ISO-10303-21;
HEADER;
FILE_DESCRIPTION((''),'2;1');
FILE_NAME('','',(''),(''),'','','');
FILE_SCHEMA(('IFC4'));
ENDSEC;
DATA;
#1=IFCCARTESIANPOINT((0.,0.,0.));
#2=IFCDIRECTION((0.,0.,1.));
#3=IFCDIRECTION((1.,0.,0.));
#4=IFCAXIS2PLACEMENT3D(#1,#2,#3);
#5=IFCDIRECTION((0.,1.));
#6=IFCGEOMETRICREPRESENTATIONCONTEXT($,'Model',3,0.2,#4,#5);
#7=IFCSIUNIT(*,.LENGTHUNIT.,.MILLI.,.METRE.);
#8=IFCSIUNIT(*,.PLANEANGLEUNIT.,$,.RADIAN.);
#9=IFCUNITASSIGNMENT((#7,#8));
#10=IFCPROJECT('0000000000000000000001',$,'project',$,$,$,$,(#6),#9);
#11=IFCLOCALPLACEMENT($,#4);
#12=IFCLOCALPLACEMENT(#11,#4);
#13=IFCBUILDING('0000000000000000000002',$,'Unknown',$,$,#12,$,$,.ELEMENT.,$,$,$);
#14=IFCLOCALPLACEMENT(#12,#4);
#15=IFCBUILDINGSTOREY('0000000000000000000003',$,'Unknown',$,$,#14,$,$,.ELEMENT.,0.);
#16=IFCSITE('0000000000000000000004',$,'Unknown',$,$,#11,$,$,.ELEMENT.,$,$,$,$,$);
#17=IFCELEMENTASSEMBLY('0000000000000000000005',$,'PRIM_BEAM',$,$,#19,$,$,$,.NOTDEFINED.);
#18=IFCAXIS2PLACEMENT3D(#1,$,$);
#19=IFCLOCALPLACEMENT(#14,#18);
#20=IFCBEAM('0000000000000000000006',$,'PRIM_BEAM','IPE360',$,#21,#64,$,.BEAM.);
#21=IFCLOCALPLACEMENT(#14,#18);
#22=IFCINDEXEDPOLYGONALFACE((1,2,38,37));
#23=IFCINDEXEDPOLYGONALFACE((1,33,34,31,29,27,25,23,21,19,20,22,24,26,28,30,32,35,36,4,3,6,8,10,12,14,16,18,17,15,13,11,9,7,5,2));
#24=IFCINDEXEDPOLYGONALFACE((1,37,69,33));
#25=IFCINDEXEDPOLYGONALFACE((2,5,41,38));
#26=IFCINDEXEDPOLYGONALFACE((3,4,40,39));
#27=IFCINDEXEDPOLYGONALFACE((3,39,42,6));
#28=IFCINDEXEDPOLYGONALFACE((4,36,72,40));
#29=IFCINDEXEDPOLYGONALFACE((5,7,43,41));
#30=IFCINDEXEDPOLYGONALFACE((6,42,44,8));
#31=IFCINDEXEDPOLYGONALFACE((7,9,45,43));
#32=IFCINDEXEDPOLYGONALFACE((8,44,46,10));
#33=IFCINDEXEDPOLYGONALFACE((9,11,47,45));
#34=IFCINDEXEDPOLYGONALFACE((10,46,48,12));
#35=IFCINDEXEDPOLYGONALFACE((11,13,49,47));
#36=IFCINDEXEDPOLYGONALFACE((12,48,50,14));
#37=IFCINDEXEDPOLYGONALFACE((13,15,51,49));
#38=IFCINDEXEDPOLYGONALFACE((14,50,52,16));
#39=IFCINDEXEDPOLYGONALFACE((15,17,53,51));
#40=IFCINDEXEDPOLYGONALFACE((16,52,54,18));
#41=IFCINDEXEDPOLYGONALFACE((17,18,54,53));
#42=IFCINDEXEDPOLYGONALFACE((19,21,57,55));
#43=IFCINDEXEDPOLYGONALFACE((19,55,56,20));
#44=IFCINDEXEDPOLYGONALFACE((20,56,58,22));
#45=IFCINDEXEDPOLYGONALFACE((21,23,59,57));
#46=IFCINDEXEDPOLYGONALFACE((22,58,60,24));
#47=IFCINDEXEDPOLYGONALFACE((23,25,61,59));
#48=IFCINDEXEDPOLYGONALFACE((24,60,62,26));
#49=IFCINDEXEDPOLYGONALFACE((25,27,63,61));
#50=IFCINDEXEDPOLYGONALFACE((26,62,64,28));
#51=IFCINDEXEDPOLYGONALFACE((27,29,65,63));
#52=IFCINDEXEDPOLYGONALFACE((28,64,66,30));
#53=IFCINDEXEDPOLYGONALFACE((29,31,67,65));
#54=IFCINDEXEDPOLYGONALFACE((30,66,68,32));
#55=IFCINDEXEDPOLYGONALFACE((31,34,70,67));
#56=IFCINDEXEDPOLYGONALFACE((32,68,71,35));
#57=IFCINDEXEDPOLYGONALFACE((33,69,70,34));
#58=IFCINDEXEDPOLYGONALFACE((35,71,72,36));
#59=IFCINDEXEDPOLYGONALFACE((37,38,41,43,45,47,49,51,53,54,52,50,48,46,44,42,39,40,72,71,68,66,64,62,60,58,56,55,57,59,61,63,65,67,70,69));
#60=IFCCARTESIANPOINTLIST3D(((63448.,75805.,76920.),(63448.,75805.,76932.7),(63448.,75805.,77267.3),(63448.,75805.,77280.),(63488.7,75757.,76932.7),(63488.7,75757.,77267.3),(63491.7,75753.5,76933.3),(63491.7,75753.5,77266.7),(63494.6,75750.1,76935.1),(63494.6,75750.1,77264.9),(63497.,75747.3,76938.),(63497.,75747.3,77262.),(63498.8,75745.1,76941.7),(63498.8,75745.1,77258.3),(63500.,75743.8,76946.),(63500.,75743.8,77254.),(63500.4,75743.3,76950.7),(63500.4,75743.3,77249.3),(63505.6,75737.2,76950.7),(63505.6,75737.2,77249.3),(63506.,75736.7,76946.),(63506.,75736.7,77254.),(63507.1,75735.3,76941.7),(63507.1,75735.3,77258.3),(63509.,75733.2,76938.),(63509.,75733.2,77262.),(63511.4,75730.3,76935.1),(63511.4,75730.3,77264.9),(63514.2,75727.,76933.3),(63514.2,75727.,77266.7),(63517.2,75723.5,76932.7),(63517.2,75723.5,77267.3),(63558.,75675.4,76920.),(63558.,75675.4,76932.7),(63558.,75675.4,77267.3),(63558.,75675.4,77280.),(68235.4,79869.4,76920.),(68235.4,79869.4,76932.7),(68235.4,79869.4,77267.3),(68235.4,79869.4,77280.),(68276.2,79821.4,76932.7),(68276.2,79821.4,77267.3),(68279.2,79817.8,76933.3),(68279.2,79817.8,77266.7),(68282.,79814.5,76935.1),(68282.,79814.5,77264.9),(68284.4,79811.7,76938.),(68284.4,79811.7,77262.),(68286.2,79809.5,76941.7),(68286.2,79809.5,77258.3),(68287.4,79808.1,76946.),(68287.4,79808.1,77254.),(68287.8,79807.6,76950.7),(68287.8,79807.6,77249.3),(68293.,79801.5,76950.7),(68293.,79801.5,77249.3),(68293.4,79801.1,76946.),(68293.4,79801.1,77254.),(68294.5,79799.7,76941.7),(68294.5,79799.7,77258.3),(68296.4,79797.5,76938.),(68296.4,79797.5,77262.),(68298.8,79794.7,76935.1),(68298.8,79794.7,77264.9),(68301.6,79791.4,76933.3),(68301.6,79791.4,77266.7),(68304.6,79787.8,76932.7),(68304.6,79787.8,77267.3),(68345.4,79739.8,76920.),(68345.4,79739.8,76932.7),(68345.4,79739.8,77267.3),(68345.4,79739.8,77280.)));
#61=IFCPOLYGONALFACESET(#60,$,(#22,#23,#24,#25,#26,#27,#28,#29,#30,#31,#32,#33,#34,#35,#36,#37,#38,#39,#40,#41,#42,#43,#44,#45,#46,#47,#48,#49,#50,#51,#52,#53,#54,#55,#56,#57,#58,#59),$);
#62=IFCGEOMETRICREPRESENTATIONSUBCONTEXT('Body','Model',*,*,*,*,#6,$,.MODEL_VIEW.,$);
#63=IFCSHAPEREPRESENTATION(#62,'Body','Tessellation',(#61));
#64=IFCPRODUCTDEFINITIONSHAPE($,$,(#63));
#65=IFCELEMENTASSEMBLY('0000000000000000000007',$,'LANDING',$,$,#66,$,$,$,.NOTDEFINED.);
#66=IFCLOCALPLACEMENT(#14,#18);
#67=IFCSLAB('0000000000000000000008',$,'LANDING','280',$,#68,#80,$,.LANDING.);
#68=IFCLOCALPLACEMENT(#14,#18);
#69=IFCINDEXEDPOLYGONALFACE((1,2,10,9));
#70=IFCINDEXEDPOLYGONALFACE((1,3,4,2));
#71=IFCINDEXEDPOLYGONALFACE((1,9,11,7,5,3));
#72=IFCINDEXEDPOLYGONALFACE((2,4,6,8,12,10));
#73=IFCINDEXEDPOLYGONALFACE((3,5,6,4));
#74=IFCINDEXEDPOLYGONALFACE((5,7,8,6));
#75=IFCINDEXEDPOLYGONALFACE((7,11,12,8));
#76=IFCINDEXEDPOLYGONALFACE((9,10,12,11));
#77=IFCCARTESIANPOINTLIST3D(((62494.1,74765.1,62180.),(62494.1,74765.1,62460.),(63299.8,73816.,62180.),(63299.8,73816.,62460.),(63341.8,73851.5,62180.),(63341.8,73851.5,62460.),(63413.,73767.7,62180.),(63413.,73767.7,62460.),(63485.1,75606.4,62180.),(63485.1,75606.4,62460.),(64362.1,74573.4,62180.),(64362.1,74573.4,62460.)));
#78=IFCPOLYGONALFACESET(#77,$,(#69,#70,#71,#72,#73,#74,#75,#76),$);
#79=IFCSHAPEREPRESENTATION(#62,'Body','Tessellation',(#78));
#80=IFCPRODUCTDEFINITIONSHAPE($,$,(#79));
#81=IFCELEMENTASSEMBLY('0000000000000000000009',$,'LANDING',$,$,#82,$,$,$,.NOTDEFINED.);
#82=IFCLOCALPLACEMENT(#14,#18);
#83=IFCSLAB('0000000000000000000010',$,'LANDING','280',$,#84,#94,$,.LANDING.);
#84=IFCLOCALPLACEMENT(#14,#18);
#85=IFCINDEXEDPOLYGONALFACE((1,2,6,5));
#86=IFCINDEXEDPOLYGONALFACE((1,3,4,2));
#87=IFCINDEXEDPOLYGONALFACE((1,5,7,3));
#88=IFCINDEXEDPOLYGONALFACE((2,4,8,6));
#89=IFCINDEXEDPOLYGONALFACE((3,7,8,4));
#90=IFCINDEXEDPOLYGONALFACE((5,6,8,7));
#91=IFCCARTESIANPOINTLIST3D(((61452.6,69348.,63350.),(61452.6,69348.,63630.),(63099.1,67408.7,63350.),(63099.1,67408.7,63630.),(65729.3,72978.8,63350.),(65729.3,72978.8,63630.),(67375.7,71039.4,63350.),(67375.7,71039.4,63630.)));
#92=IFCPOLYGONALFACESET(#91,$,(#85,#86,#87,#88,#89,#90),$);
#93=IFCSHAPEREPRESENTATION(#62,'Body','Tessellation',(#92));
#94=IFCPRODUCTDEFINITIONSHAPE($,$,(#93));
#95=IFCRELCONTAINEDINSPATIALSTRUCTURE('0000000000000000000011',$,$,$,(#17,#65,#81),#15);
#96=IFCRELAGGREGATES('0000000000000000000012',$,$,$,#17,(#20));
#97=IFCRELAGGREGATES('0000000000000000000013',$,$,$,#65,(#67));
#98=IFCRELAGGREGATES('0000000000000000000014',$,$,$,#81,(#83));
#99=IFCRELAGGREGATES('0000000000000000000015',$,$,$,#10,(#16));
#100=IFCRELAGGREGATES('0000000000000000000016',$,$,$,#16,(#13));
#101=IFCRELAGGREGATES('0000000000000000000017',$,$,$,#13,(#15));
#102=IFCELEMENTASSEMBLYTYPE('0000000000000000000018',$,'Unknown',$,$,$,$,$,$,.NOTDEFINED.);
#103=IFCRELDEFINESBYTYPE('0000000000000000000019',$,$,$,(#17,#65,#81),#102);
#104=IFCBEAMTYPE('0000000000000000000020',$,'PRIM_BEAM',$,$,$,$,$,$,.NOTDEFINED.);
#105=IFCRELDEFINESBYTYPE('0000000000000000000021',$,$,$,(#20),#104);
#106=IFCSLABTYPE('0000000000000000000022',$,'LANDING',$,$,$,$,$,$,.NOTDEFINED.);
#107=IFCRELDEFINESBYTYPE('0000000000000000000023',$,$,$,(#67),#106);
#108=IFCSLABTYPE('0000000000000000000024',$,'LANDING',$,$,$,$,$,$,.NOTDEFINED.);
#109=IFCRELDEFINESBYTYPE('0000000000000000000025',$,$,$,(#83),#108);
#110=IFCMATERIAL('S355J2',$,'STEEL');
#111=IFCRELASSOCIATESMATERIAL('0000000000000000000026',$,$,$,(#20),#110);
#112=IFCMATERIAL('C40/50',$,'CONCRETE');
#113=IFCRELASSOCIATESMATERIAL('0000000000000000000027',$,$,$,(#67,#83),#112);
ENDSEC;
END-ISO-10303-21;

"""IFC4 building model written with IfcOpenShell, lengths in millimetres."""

from ifc_helpers import new_model, si_unit, direction, frame, origin_with_axes, origin_2d_with_axis, place, context, subcontext, project, spatial, line, indexed_curve, i_section, outline, extrude, material, material_profile, profile_set, profile_usage, type_object, element, aggregate, save


model = new_model("IFC4")

# Units and contexts
model_context = context("Model", 3, precision=0.2, world=origin_with_axes(), true_north=direction((0.0, 1.0)))
body_context = subcontext(model_context, "Body", "Model", "MODEL_VIEW")
ifc_project = project(units=[si_unit("LENGTHUNIT", "METRE", prefix="MILLI"), si_unit("PLANEANGLEUNIT", "RADIAN")], contexts=[model_context])

# Site, building, storey
site_placement = place(None, origin_with_axes())
site = spatial("IfcSite", under=ifc_project, at=site_placement, Name="Unknown", CompositionType="ELEMENT")
building_placement = place(site_placement, origin_with_axes())
building = spatial("IfcBuilding", under=site, at=building_placement, Name="Unknown", CompositionType="ELEMENT")
storey_placement = place(building_placement, origin_with_axes())
storey = spatial("IfcBuildingStorey", under=building, at=storey_placement, Name="Unknown", CompositionType="ELEMENT", Elevation=0.0)

# Shared definitions
element_assembly_type = type_object("IfcElementAssemblyType", Name="Unknown", PredefinedType="NOTDEFINED")
ifc_material_1 = material(Name="C40/50", Category="CONCRETE")
ifc_material_2 = material(Name="S355J2", Category="STEEL")

# Element assembly, beam
ifc_material_profile_1 = material_profile(ifc_material_2, i_section(OverallWidth=170.0, OverallDepth=360.0, WebThickness=8.0, FlangeThickness=12.7, FilletRadius=18.0, FlangeEdgeRadius=0.0, FlangeSlope=0.0, at=origin_2d_with_axis()), Name="IPE360")
ifc_profile_set_1 = profile_set([ifc_material_profile_1])
ifc_profile_usage_1 = profile_usage(ifc_profile_set_1, cardinal=2)
beam_type_1 = type_object("IfcBeamType", Name="PRIM_BEAM")
assembly_1_placement = place(storey_placement, frame((68290.4, 79804.6, 77100.0), z_axis=(-0.64719, 0.762329, 0.0), x_axis=(-0.762329, -0.64719, 0.0)))
assembly_1 = element("IfcElementAssembly", 1, at=assembly_1_placement, inside=storey, type_object=element_assembly_type, Name="PRIM_BEAM", PredefinedType="NOTDEFINED")
beam_1_placement = place(assembly_1_placement, origin_with_axes())
beam_1 = element("IfcBeam", 2, at=beam_1_placement, type_object=beam_type_1, material=ifc_profile_usage_1, Name="PRIM_BEAM", Description="IPE360", PredefinedType="BEAM", context=body_context, shape_type="SolidModel", body=[
    extrude(i_section(OverallWidth=170.0, OverallDepth=360.0, WebThickness=8.0, FlangeThickness=12.7, FilletRadius=18.0, FlangeEdgeRadius=0.0, FlangeSlope=0.0, at=origin_2d_with_axis()), frame((0.0, 0.0, 0.0), z_axis=(-1.0, 0.0, 0.0), x_axis=(0.0, 0.0, 1.0)), (0.0, 0.0, -1.0), 6280.0),
])
aggregate(assembly_1, [beam_1])

# Element assemblies, slabs
assembly_2_placement = place(storey_placement, frame((62494.1, 74765.1, 62320.0), z_axis=(0.0, 0.0, -1.0), x_axis=(0.762329, 0.64719, 0.0)))
assembly_2 = element("IfcElementAssembly", 3, at=assembly_2_placement, inside=storey, type_object=element_assembly_type, Name="LANDING", PredefinedType="NOTDEFINED")
ifc_material_profile_2 = material_profile(ifc_material_1, outline(indexed_curve([(0.0, 0.0), (1300.0, 0.0), (1300.0, 1355.0), (55.0, 1355.0), (55.0, 1245.0), (0.0, 1245.0)], segments=[line(1, 2, 3, 4, 5, 6, 1)])), Name="280")
ifc_profile_set_2 = profile_set([ifc_material_profile_2])
ifc_profile_usage_2 = profile_usage(ifc_profile_set_2, cardinal=2)
slab_type_1 = type_object("IfcSlabType", Name="LANDING")
slab_1_placement = place(assembly_2_placement, origin_with_axes())
slab_1 = element("IfcSlab", 4, at=slab_1_placement, type_object=slab_type_1, material=ifc_profile_usage_2, Name="LANDING", Description="280", PredefinedType="LANDING", context=body_context, shape_type="SolidModel", body=[
    extrude(outline(indexed_curve([(0.0, 0.0), (1300.0, 0.0), (1300.0, 1355.0), (55.0, 1355.0), (55.0, 1245.0), (0.0, 1245.0)], segments=[line(1, 2, 3, 4, 5, 6, 1)])), frame((0.0, 0.0, 140.0), z_axis=(0.0, 0.0, 1.0), x_axis=(1.0, 0.0, 0.0)), (0.0, 0.0, -1.0), 280.0),
])
aggregate(assembly_2, [slab_1])
assembly_3_placement = place(storey_placement, frame((63099.1, 67408.7, 63490.0), z_axis=(0.0, 0.0, 1.0), x_axis=(0.762329, 0.64719, 0.0)))
assembly_3 = element("IfcElementAssembly", 5, at=assembly_3_placement, inside=storey, type_object=element_assembly_type, Name="LANDING", PredefinedType="NOTDEFINED")
ifc_material_profile_3 = material_profile(ifc_material_1, outline(indexed_curve([(0.0, 0.0), (5610.0, 0.0), (5610.0, 2544.0), (0.0, 2544.0)], segments=[line(1, 2, 3, 4, 1)])), Name="280")
ifc_profile_set_3 = profile_set([ifc_material_profile_3])
ifc_profile_usage_3 = profile_usage(ifc_profile_set_3, cardinal=8)
slab_type_2 = type_object("IfcSlabType", Name="LANDING")
slab_2_placement = place(assembly_3_placement, origin_with_axes())
slab_2 = element("IfcSlab", 6, at=slab_2_placement, type_object=slab_type_2, material=ifc_profile_usage_3, Name="LANDING", Description="280", PredefinedType="LANDING", context=body_context, shape_type="SolidModel", body=[
    extrude(outline(indexed_curve([(0.0, 0.0), (5610.0, 0.0), (5610.0, 2544.0), (0.0, 2544.0)], segments=[line(1, 2, 3, 4, 1)])), frame((0.0, 0.0, 140.0), z_axis=(0.0, 0.0, 1.0), x_axis=(1.0, 0.0, 0.0)), (0.0, 0.0, -1.0), 280.0),
])
aggregate(assembly_3, [slab_2])

save(model, "model.ifc")
